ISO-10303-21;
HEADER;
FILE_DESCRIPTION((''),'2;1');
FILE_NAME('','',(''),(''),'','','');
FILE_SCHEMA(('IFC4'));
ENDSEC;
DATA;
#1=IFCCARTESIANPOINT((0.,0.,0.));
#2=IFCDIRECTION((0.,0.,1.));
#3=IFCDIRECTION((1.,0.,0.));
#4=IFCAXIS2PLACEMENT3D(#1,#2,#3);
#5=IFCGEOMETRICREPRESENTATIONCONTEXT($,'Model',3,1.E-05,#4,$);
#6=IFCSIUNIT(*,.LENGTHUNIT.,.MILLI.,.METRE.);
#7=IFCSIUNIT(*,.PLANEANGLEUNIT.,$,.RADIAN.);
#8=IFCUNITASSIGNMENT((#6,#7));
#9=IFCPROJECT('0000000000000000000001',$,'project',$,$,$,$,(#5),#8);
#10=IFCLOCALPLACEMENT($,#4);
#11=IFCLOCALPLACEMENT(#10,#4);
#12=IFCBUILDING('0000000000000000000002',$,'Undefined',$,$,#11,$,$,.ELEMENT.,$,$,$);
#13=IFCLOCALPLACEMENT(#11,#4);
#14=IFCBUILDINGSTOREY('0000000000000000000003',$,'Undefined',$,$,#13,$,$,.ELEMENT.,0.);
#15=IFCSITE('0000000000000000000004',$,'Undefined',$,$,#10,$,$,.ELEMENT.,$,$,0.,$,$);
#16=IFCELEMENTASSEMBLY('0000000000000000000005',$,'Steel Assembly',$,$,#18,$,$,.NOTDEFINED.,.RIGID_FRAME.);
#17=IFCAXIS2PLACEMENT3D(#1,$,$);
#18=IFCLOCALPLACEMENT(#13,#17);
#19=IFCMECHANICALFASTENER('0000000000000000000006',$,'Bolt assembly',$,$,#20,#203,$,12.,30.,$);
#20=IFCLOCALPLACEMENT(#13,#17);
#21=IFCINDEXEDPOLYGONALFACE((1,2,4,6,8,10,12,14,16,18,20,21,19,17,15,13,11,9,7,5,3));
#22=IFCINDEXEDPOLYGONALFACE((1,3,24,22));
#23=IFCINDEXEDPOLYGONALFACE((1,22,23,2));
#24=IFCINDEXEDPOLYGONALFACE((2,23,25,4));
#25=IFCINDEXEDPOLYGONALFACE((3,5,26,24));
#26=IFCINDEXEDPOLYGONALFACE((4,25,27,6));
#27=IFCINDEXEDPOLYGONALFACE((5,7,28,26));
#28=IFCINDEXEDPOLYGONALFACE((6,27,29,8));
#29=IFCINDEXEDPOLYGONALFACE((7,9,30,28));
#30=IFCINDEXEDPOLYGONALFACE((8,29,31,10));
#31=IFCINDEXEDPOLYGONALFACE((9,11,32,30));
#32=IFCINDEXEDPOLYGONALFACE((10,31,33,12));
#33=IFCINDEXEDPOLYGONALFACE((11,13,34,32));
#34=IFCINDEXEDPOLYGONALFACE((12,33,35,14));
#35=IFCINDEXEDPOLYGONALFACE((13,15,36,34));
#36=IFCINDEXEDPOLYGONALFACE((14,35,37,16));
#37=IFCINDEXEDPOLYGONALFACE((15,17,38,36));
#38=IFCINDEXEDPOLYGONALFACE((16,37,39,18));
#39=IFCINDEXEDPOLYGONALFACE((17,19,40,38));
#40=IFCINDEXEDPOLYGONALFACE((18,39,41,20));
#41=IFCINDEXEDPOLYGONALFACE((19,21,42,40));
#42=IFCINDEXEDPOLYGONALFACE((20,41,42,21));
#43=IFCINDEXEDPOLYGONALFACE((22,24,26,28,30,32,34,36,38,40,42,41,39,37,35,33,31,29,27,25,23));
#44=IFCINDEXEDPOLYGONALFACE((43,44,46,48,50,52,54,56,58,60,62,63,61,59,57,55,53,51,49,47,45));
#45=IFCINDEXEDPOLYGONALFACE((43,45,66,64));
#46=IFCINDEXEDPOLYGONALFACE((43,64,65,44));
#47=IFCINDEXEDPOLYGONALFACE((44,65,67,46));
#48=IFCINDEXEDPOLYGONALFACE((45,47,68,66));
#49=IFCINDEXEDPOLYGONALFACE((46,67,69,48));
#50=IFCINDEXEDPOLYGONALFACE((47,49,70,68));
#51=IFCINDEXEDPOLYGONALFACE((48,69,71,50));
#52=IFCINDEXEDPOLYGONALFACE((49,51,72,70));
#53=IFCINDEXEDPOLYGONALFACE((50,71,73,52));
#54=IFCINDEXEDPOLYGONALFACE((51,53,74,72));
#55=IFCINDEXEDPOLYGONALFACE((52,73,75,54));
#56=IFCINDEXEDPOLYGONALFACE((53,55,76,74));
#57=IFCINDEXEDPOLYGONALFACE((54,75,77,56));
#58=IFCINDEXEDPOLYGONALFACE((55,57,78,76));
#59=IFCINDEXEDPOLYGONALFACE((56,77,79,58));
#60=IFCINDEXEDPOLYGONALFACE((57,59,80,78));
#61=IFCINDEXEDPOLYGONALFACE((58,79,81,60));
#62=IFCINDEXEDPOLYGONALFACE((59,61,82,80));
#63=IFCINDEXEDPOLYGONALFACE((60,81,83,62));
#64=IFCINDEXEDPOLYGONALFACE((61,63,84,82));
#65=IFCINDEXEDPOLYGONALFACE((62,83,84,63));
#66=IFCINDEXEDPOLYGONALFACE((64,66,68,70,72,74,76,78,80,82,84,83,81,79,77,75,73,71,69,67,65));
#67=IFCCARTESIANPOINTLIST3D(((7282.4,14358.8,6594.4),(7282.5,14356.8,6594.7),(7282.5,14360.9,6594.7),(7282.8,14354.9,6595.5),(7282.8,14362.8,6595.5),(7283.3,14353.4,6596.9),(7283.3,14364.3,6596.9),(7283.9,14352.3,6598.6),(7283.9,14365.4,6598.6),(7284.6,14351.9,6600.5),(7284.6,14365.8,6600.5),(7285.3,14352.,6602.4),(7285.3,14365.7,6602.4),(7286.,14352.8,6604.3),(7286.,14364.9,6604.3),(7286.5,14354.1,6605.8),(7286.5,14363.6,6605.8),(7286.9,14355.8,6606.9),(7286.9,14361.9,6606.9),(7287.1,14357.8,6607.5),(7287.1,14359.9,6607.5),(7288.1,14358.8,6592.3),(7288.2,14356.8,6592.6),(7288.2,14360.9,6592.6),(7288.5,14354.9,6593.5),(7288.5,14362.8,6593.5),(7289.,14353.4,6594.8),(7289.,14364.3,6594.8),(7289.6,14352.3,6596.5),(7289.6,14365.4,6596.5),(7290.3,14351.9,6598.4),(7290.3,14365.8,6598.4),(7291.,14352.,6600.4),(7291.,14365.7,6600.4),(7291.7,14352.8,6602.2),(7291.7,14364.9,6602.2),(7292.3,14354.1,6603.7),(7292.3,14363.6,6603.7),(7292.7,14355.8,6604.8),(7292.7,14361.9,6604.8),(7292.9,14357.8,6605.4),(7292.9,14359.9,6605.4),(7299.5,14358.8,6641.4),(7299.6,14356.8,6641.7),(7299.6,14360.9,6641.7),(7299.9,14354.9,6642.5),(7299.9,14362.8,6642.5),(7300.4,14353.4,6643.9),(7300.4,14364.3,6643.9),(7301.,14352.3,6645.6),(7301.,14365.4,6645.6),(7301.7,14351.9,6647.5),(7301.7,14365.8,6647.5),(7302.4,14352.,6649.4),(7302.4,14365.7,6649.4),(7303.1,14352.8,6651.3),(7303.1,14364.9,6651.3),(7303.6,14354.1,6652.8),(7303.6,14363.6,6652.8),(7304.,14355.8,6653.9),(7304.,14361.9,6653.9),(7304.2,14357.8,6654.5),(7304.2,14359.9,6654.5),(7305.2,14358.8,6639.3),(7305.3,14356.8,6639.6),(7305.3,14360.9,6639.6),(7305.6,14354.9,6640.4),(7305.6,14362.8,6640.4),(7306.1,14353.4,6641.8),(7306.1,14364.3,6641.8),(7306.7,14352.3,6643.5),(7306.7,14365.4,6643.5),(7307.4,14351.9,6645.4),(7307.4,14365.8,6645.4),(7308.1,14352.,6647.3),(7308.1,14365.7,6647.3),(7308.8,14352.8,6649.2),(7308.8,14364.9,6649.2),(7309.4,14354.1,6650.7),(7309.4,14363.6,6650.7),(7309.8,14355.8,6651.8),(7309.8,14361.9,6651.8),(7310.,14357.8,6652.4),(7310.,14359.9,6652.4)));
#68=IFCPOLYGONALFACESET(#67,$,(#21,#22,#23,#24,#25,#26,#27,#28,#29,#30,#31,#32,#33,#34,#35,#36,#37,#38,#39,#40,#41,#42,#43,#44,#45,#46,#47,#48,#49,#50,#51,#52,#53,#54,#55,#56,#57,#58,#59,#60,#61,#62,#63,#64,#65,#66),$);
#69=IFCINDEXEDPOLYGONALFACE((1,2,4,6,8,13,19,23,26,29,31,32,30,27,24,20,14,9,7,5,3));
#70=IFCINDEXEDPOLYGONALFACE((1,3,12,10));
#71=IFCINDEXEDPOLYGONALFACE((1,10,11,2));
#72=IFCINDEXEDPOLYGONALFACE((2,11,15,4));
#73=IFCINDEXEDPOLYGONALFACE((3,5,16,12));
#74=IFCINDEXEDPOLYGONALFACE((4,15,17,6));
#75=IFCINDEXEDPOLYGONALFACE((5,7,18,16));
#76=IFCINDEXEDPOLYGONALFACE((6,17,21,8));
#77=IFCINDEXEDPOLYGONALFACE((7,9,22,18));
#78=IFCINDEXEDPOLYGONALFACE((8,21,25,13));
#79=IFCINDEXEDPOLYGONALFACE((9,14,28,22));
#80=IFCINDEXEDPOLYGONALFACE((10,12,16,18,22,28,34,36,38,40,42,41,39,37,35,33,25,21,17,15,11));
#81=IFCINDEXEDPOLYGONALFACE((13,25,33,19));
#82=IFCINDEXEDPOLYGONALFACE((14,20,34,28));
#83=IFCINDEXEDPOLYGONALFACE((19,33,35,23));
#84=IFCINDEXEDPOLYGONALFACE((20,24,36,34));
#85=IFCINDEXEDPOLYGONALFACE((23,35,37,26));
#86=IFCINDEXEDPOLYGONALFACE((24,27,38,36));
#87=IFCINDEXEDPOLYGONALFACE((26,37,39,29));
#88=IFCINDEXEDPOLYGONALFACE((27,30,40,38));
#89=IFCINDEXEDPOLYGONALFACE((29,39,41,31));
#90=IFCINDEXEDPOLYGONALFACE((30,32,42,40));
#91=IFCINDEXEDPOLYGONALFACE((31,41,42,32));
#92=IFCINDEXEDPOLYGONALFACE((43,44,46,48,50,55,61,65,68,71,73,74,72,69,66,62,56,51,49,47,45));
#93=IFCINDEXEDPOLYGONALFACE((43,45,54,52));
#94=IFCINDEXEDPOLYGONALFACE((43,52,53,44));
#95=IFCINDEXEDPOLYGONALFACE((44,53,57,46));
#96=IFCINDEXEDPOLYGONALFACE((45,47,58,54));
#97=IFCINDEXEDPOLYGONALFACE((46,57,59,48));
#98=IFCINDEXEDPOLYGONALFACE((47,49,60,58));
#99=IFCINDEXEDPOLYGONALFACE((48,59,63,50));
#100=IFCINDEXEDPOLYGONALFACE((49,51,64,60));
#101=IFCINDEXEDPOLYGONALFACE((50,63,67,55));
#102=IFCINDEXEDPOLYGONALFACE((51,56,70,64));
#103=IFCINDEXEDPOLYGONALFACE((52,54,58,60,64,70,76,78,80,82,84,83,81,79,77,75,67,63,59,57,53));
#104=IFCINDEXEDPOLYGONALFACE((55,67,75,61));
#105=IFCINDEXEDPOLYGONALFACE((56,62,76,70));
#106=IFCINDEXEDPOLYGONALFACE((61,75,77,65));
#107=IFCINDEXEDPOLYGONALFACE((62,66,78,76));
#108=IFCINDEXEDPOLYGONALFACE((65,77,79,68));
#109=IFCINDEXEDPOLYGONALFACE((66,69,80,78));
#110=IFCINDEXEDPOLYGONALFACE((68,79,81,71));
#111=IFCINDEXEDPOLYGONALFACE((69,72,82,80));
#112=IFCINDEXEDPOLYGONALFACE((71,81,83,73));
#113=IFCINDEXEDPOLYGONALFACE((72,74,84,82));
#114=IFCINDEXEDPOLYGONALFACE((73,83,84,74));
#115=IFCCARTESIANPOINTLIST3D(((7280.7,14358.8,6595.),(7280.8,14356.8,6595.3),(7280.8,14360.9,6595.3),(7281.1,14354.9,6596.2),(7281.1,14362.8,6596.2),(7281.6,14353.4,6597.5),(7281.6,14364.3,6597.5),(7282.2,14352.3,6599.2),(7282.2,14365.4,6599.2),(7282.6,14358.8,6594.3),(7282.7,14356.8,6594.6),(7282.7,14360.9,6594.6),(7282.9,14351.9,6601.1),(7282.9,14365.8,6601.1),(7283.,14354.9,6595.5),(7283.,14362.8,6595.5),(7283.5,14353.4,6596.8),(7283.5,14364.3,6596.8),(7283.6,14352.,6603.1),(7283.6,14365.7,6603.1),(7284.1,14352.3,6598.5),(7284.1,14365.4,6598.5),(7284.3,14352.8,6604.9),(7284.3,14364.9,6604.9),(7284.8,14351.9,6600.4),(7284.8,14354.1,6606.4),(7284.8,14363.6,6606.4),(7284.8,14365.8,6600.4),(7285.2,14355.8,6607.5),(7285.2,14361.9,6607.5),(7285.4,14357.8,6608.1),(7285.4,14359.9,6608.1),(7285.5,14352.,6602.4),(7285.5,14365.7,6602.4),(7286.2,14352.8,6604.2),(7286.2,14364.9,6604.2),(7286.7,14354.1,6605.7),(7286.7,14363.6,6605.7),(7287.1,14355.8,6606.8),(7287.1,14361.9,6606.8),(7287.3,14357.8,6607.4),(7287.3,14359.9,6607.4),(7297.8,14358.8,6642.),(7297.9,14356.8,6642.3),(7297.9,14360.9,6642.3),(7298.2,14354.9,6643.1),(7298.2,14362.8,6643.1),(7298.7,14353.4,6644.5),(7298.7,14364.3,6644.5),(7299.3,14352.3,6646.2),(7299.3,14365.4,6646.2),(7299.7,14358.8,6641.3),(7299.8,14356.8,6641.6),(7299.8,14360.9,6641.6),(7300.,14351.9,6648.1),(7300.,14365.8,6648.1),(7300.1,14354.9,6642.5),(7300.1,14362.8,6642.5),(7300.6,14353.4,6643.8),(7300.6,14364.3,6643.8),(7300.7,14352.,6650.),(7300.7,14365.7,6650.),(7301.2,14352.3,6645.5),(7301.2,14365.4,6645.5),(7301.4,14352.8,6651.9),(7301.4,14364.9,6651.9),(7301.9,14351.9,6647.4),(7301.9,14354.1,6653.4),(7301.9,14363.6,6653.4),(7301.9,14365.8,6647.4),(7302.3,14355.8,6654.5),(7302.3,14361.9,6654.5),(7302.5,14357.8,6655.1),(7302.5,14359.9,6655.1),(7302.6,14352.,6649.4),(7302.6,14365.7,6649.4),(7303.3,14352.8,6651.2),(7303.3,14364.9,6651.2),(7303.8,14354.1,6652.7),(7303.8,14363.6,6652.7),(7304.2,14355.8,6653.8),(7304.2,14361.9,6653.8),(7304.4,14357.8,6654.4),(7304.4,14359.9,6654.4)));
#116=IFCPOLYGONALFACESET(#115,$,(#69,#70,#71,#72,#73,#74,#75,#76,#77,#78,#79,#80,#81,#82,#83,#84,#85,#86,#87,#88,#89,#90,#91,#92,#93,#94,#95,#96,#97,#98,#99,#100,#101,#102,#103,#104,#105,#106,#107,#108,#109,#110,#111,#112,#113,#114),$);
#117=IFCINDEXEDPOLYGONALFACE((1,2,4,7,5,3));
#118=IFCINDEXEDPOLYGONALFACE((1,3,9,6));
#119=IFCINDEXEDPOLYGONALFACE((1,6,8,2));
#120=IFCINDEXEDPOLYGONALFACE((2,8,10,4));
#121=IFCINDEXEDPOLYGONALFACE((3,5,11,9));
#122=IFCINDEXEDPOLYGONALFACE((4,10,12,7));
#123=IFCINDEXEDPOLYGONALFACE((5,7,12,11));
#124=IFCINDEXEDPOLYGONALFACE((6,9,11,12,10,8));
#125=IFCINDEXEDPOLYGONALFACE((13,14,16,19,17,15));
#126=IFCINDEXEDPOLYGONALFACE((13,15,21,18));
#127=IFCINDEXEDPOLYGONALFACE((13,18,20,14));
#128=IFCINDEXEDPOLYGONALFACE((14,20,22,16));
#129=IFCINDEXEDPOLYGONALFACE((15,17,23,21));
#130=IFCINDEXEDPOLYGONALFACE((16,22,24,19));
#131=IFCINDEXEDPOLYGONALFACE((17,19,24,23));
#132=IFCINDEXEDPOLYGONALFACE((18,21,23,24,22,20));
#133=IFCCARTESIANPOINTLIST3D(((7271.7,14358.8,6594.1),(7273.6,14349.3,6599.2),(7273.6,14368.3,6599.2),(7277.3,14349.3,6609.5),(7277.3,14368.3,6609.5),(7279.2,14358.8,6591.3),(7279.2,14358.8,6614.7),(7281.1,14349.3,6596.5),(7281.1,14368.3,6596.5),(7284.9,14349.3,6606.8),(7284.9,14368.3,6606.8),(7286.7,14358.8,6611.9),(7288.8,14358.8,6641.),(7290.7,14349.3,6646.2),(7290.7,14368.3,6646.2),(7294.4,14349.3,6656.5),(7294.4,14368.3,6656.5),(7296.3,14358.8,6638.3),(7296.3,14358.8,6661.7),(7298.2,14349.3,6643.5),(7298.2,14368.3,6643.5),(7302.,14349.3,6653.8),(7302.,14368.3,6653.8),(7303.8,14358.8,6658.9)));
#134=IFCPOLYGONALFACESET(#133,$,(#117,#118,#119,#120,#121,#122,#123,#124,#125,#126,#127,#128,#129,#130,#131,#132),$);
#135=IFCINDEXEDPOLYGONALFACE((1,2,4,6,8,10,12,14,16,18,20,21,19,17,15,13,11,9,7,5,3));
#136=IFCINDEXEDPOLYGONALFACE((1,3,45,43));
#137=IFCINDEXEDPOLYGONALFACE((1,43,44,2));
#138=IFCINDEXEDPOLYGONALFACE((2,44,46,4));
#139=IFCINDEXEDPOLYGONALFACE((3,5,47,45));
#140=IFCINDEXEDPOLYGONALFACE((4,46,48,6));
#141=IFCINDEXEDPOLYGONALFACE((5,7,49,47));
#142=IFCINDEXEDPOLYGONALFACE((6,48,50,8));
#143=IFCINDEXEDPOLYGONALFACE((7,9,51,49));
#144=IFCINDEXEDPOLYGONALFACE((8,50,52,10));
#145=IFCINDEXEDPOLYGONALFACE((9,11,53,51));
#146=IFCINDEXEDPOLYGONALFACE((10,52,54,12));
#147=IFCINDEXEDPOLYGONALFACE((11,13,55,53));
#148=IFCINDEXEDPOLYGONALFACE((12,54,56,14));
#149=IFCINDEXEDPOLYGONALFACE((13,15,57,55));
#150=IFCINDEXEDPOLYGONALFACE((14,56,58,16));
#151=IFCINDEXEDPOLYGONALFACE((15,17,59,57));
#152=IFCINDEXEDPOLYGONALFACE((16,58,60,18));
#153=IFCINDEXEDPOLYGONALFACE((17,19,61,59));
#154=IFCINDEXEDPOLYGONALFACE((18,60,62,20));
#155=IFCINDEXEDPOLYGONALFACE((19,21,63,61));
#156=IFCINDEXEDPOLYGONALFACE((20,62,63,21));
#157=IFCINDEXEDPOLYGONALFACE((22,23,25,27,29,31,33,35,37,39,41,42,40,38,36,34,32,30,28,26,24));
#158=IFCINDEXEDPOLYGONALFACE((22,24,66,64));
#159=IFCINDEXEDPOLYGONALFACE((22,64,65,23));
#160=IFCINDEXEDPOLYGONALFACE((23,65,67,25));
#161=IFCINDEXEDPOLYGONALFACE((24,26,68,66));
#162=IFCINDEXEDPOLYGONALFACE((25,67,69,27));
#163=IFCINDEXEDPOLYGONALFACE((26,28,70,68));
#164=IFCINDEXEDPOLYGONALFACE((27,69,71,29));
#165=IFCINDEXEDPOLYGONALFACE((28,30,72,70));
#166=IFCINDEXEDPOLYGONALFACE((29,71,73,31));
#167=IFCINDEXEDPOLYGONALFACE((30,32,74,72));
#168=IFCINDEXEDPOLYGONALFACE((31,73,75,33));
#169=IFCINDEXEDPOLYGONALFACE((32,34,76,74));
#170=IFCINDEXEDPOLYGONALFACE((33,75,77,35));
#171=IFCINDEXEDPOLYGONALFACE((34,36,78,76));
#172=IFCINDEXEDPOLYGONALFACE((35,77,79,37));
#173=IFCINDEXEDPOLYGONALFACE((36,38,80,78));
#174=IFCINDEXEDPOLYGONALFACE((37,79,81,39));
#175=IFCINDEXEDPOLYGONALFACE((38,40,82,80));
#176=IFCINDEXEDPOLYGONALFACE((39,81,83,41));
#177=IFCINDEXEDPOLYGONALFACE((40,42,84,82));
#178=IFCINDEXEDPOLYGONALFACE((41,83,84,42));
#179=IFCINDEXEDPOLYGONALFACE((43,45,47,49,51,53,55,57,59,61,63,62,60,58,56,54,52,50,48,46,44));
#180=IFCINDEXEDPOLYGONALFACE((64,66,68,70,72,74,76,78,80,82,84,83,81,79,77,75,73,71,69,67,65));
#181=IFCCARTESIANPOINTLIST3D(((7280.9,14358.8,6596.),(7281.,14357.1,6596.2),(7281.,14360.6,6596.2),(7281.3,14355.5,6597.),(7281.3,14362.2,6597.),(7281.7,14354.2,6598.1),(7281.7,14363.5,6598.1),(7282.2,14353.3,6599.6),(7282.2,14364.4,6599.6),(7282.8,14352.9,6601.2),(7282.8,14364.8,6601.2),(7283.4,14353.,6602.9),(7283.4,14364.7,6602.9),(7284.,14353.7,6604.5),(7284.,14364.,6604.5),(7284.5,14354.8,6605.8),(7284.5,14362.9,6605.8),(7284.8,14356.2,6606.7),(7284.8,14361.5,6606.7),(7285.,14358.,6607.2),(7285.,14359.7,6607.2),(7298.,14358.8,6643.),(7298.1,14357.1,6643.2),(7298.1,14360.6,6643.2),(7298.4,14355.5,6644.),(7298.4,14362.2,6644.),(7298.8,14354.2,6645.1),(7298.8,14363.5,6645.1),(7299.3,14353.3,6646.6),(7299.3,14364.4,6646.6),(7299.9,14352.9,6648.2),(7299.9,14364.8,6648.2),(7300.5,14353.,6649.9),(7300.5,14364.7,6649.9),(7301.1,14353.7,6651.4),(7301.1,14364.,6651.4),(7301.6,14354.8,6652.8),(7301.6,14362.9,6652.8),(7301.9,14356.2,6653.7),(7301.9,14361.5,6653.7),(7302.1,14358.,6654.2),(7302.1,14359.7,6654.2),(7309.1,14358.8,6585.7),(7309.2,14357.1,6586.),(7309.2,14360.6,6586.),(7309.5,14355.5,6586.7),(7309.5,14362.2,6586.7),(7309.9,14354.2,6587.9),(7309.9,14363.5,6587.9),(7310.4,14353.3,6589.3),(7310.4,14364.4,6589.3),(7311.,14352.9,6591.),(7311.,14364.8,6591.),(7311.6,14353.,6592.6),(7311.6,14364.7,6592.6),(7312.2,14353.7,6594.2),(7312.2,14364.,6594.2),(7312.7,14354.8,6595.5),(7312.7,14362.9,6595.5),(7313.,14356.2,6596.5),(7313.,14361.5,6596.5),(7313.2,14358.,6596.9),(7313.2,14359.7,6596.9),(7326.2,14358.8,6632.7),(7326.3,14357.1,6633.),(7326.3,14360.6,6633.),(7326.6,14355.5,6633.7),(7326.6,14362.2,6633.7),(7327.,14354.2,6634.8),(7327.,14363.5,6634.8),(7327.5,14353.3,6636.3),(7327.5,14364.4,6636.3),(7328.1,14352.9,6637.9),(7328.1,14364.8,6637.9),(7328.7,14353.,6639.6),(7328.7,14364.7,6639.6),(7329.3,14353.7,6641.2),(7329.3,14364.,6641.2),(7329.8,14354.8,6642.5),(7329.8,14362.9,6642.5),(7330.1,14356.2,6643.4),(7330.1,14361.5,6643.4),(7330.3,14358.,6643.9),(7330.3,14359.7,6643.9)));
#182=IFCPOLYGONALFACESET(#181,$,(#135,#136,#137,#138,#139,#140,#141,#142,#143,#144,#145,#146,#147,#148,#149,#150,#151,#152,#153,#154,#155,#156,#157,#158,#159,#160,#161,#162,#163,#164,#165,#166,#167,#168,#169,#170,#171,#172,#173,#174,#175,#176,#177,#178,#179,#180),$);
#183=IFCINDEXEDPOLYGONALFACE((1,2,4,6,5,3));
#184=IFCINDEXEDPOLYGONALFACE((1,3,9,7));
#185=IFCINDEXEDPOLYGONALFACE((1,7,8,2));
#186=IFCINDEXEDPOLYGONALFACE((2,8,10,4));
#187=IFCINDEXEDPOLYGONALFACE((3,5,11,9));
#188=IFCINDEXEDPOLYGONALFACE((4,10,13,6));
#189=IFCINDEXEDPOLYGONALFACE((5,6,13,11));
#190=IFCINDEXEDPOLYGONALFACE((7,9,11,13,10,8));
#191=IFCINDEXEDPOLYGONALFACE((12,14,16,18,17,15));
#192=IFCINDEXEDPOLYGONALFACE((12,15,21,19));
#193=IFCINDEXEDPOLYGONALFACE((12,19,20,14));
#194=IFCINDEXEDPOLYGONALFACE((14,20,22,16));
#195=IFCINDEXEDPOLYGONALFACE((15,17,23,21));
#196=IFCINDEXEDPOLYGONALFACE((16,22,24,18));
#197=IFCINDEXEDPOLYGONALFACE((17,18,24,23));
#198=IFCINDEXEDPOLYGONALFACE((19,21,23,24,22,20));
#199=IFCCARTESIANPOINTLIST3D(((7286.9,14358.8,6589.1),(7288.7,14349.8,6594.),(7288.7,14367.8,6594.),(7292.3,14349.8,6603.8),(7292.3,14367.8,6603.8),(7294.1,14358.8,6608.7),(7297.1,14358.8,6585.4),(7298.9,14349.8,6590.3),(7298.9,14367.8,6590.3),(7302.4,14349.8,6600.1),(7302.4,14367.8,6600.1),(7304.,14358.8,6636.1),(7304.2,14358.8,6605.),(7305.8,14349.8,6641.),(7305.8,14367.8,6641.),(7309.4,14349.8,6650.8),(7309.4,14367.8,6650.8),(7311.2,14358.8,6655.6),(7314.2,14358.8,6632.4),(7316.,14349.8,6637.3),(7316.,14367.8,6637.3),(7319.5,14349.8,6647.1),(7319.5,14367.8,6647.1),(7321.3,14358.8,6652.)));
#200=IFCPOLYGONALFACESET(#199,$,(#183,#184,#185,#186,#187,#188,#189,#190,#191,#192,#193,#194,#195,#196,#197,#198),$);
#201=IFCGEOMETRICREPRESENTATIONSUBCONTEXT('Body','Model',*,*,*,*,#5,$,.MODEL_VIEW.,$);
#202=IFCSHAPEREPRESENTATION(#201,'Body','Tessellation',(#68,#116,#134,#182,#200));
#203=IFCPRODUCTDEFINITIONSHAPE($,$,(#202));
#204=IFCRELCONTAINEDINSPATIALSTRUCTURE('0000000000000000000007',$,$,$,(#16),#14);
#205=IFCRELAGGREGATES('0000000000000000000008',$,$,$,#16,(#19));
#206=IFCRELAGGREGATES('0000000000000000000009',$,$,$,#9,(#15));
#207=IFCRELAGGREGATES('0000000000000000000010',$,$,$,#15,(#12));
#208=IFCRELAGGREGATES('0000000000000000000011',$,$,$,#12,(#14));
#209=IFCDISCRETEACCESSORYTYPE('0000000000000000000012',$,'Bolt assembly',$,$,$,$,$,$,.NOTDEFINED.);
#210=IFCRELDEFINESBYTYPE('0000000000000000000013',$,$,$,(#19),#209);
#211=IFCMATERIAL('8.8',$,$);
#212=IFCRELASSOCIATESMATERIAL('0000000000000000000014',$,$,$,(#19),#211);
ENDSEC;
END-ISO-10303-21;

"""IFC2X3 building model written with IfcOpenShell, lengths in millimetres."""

from ifc_helpers import new_model, si_unit, frame, origin_with_axes, origin_2d_with_axis, place, context, subcontext, project, spatial, polyline, circle, outline, extrude, source, transform, mapped, material, type_object, element, aggregate, save


model = new_model("IFC2X3")

# Units and contexts
model_context = context("Model", 3, precision=1e-05, world=origin_with_axes())
body_context = subcontext(model_context, "Body", "Model", "MODEL_VIEW")
ifc_project = project(units=[si_unit("LENGTHUNIT", "METRE", prefix="MILLI"), si_unit("PLANEANGLEUNIT", "RADIAN")], contexts=[model_context])

# Site, building, storey
site_placement = place(None, origin_with_axes())
site = spatial("IfcSite", under=ifc_project, at=site_placement, Name="Undefined", CompositionType="ELEMENT", RefElevation=0.0)
building_placement = place(site_placement, origin_with_axes())
building = spatial("IfcBuilding", under=site, at=building_placement, Name="Undefined", CompositionType="ELEMENT")
storey_placement = place(building_placement, origin_with_axes())
storey = spatial("IfcBuildingStorey", under=building, at=storey_placement, Name="Undefined", CompositionType="ELEMENT", Elevation=0.0)

# Shared definitions
ifc_material_1 = material(Name="8.8")
discrete_accessory_type_1 = type_object("IfcDiscreteAccessoryType", Name="Bolt assembly")

# Element assembly, mechanical fastener
assembly_1_placement = place(storey_placement, origin_with_axes())
assembly_1 = element("IfcElementAssembly", 1, at=assembly_1_placement, inside=storey, Name="Steel Assembly", AssemblyPlace="NOTDEFINED", PredefinedType="RIGID_FRAME")
shared_shape_1 = source(origin_with_axes(), body_context, "Body", "SweptSolid", [
    extrude(circle(Radius=7.0, at=origin_2d_with_axis()), frame((0.0, -6.1, 0.0), z_axis=(0.0, 1.0, 0.0), x_axis=(1.0, 0.0, 0.0)), (0.0, 0.0, 1.0), 6.1),
    extrude(circle(Radius=7.0, at=origin_2d_with_axis()), frame((0.0, -7.9, 0.0), z_axis=(0.0, 1.0, 0.0), x_axis=(1.0, 0.0, 0.0)), (0.0, 0.0, 1.0), 2.0),
    extrude(outline(polyline([(11.0, 0.0), (5.5, 9.5), (-5.5, 9.5), (-11.0, 0.0), (-5.5, -9.5), (5.5, -9.5), (11.0, 0.0)])), frame((0.0, -16.0, 0.0), z_axis=(0.0, 1.0, 0.0), x_axis=(1.0, 0.0, 0.0)), (0.0, 0.0, 1.0), 8.0),
    extrude(circle(Radius=6.0, at=origin_2d_with_axis()), frame((0.0, -8.0, 0.0), z_axis=(0.0, 1.0, 0.0), x_axis=(1.0, 0.0, 0.0)), (0.0, 0.0, 1.0), 30.0),
    extrude(outline(polyline([(10.4, 0.0), (5.2, 9.0), (-5.2, 9.0), (-10.4, 0.0), (-5.2, -9.0), (5.2, -9.0), (10.4, 0.0)])), frame((0.0, 0.0, 0.0), z_axis=(0.0, 1.0, 0.0), x_axis=(1.0, 0.0, 0.0)), (0.0, 0.0, 1.0), 10.8),
])
mechanical_fastener_1_placement = place(assembly_1_placement, frame((7307.6, 14358.8, 6645.9), z_axis=(0.0, -1.0, 0.0), x_axis=(-0.34202, 0.0, -0.939693)))
mechanical_fastener_1 = element("IfcMechanicalFastener", 2, at=mechanical_fastener_1_placement, type_object=discrete_accessory_type_1, material=ifc_material_1, Name="Bolt assembly", NominalDiameter=12.0, NominalLength=30.0, context=body_context, shape_type="MappedRepresentation", body=[
    mapped(shared_shape_1, transform((0.0, 0.0, 0.0))),
    mapped(shared_shape_1, transform((50.0, 0.0, 0.0))),
])
aggregate(assembly_1, [mechanical_fastener_1])

save(model, "model.ifc")
